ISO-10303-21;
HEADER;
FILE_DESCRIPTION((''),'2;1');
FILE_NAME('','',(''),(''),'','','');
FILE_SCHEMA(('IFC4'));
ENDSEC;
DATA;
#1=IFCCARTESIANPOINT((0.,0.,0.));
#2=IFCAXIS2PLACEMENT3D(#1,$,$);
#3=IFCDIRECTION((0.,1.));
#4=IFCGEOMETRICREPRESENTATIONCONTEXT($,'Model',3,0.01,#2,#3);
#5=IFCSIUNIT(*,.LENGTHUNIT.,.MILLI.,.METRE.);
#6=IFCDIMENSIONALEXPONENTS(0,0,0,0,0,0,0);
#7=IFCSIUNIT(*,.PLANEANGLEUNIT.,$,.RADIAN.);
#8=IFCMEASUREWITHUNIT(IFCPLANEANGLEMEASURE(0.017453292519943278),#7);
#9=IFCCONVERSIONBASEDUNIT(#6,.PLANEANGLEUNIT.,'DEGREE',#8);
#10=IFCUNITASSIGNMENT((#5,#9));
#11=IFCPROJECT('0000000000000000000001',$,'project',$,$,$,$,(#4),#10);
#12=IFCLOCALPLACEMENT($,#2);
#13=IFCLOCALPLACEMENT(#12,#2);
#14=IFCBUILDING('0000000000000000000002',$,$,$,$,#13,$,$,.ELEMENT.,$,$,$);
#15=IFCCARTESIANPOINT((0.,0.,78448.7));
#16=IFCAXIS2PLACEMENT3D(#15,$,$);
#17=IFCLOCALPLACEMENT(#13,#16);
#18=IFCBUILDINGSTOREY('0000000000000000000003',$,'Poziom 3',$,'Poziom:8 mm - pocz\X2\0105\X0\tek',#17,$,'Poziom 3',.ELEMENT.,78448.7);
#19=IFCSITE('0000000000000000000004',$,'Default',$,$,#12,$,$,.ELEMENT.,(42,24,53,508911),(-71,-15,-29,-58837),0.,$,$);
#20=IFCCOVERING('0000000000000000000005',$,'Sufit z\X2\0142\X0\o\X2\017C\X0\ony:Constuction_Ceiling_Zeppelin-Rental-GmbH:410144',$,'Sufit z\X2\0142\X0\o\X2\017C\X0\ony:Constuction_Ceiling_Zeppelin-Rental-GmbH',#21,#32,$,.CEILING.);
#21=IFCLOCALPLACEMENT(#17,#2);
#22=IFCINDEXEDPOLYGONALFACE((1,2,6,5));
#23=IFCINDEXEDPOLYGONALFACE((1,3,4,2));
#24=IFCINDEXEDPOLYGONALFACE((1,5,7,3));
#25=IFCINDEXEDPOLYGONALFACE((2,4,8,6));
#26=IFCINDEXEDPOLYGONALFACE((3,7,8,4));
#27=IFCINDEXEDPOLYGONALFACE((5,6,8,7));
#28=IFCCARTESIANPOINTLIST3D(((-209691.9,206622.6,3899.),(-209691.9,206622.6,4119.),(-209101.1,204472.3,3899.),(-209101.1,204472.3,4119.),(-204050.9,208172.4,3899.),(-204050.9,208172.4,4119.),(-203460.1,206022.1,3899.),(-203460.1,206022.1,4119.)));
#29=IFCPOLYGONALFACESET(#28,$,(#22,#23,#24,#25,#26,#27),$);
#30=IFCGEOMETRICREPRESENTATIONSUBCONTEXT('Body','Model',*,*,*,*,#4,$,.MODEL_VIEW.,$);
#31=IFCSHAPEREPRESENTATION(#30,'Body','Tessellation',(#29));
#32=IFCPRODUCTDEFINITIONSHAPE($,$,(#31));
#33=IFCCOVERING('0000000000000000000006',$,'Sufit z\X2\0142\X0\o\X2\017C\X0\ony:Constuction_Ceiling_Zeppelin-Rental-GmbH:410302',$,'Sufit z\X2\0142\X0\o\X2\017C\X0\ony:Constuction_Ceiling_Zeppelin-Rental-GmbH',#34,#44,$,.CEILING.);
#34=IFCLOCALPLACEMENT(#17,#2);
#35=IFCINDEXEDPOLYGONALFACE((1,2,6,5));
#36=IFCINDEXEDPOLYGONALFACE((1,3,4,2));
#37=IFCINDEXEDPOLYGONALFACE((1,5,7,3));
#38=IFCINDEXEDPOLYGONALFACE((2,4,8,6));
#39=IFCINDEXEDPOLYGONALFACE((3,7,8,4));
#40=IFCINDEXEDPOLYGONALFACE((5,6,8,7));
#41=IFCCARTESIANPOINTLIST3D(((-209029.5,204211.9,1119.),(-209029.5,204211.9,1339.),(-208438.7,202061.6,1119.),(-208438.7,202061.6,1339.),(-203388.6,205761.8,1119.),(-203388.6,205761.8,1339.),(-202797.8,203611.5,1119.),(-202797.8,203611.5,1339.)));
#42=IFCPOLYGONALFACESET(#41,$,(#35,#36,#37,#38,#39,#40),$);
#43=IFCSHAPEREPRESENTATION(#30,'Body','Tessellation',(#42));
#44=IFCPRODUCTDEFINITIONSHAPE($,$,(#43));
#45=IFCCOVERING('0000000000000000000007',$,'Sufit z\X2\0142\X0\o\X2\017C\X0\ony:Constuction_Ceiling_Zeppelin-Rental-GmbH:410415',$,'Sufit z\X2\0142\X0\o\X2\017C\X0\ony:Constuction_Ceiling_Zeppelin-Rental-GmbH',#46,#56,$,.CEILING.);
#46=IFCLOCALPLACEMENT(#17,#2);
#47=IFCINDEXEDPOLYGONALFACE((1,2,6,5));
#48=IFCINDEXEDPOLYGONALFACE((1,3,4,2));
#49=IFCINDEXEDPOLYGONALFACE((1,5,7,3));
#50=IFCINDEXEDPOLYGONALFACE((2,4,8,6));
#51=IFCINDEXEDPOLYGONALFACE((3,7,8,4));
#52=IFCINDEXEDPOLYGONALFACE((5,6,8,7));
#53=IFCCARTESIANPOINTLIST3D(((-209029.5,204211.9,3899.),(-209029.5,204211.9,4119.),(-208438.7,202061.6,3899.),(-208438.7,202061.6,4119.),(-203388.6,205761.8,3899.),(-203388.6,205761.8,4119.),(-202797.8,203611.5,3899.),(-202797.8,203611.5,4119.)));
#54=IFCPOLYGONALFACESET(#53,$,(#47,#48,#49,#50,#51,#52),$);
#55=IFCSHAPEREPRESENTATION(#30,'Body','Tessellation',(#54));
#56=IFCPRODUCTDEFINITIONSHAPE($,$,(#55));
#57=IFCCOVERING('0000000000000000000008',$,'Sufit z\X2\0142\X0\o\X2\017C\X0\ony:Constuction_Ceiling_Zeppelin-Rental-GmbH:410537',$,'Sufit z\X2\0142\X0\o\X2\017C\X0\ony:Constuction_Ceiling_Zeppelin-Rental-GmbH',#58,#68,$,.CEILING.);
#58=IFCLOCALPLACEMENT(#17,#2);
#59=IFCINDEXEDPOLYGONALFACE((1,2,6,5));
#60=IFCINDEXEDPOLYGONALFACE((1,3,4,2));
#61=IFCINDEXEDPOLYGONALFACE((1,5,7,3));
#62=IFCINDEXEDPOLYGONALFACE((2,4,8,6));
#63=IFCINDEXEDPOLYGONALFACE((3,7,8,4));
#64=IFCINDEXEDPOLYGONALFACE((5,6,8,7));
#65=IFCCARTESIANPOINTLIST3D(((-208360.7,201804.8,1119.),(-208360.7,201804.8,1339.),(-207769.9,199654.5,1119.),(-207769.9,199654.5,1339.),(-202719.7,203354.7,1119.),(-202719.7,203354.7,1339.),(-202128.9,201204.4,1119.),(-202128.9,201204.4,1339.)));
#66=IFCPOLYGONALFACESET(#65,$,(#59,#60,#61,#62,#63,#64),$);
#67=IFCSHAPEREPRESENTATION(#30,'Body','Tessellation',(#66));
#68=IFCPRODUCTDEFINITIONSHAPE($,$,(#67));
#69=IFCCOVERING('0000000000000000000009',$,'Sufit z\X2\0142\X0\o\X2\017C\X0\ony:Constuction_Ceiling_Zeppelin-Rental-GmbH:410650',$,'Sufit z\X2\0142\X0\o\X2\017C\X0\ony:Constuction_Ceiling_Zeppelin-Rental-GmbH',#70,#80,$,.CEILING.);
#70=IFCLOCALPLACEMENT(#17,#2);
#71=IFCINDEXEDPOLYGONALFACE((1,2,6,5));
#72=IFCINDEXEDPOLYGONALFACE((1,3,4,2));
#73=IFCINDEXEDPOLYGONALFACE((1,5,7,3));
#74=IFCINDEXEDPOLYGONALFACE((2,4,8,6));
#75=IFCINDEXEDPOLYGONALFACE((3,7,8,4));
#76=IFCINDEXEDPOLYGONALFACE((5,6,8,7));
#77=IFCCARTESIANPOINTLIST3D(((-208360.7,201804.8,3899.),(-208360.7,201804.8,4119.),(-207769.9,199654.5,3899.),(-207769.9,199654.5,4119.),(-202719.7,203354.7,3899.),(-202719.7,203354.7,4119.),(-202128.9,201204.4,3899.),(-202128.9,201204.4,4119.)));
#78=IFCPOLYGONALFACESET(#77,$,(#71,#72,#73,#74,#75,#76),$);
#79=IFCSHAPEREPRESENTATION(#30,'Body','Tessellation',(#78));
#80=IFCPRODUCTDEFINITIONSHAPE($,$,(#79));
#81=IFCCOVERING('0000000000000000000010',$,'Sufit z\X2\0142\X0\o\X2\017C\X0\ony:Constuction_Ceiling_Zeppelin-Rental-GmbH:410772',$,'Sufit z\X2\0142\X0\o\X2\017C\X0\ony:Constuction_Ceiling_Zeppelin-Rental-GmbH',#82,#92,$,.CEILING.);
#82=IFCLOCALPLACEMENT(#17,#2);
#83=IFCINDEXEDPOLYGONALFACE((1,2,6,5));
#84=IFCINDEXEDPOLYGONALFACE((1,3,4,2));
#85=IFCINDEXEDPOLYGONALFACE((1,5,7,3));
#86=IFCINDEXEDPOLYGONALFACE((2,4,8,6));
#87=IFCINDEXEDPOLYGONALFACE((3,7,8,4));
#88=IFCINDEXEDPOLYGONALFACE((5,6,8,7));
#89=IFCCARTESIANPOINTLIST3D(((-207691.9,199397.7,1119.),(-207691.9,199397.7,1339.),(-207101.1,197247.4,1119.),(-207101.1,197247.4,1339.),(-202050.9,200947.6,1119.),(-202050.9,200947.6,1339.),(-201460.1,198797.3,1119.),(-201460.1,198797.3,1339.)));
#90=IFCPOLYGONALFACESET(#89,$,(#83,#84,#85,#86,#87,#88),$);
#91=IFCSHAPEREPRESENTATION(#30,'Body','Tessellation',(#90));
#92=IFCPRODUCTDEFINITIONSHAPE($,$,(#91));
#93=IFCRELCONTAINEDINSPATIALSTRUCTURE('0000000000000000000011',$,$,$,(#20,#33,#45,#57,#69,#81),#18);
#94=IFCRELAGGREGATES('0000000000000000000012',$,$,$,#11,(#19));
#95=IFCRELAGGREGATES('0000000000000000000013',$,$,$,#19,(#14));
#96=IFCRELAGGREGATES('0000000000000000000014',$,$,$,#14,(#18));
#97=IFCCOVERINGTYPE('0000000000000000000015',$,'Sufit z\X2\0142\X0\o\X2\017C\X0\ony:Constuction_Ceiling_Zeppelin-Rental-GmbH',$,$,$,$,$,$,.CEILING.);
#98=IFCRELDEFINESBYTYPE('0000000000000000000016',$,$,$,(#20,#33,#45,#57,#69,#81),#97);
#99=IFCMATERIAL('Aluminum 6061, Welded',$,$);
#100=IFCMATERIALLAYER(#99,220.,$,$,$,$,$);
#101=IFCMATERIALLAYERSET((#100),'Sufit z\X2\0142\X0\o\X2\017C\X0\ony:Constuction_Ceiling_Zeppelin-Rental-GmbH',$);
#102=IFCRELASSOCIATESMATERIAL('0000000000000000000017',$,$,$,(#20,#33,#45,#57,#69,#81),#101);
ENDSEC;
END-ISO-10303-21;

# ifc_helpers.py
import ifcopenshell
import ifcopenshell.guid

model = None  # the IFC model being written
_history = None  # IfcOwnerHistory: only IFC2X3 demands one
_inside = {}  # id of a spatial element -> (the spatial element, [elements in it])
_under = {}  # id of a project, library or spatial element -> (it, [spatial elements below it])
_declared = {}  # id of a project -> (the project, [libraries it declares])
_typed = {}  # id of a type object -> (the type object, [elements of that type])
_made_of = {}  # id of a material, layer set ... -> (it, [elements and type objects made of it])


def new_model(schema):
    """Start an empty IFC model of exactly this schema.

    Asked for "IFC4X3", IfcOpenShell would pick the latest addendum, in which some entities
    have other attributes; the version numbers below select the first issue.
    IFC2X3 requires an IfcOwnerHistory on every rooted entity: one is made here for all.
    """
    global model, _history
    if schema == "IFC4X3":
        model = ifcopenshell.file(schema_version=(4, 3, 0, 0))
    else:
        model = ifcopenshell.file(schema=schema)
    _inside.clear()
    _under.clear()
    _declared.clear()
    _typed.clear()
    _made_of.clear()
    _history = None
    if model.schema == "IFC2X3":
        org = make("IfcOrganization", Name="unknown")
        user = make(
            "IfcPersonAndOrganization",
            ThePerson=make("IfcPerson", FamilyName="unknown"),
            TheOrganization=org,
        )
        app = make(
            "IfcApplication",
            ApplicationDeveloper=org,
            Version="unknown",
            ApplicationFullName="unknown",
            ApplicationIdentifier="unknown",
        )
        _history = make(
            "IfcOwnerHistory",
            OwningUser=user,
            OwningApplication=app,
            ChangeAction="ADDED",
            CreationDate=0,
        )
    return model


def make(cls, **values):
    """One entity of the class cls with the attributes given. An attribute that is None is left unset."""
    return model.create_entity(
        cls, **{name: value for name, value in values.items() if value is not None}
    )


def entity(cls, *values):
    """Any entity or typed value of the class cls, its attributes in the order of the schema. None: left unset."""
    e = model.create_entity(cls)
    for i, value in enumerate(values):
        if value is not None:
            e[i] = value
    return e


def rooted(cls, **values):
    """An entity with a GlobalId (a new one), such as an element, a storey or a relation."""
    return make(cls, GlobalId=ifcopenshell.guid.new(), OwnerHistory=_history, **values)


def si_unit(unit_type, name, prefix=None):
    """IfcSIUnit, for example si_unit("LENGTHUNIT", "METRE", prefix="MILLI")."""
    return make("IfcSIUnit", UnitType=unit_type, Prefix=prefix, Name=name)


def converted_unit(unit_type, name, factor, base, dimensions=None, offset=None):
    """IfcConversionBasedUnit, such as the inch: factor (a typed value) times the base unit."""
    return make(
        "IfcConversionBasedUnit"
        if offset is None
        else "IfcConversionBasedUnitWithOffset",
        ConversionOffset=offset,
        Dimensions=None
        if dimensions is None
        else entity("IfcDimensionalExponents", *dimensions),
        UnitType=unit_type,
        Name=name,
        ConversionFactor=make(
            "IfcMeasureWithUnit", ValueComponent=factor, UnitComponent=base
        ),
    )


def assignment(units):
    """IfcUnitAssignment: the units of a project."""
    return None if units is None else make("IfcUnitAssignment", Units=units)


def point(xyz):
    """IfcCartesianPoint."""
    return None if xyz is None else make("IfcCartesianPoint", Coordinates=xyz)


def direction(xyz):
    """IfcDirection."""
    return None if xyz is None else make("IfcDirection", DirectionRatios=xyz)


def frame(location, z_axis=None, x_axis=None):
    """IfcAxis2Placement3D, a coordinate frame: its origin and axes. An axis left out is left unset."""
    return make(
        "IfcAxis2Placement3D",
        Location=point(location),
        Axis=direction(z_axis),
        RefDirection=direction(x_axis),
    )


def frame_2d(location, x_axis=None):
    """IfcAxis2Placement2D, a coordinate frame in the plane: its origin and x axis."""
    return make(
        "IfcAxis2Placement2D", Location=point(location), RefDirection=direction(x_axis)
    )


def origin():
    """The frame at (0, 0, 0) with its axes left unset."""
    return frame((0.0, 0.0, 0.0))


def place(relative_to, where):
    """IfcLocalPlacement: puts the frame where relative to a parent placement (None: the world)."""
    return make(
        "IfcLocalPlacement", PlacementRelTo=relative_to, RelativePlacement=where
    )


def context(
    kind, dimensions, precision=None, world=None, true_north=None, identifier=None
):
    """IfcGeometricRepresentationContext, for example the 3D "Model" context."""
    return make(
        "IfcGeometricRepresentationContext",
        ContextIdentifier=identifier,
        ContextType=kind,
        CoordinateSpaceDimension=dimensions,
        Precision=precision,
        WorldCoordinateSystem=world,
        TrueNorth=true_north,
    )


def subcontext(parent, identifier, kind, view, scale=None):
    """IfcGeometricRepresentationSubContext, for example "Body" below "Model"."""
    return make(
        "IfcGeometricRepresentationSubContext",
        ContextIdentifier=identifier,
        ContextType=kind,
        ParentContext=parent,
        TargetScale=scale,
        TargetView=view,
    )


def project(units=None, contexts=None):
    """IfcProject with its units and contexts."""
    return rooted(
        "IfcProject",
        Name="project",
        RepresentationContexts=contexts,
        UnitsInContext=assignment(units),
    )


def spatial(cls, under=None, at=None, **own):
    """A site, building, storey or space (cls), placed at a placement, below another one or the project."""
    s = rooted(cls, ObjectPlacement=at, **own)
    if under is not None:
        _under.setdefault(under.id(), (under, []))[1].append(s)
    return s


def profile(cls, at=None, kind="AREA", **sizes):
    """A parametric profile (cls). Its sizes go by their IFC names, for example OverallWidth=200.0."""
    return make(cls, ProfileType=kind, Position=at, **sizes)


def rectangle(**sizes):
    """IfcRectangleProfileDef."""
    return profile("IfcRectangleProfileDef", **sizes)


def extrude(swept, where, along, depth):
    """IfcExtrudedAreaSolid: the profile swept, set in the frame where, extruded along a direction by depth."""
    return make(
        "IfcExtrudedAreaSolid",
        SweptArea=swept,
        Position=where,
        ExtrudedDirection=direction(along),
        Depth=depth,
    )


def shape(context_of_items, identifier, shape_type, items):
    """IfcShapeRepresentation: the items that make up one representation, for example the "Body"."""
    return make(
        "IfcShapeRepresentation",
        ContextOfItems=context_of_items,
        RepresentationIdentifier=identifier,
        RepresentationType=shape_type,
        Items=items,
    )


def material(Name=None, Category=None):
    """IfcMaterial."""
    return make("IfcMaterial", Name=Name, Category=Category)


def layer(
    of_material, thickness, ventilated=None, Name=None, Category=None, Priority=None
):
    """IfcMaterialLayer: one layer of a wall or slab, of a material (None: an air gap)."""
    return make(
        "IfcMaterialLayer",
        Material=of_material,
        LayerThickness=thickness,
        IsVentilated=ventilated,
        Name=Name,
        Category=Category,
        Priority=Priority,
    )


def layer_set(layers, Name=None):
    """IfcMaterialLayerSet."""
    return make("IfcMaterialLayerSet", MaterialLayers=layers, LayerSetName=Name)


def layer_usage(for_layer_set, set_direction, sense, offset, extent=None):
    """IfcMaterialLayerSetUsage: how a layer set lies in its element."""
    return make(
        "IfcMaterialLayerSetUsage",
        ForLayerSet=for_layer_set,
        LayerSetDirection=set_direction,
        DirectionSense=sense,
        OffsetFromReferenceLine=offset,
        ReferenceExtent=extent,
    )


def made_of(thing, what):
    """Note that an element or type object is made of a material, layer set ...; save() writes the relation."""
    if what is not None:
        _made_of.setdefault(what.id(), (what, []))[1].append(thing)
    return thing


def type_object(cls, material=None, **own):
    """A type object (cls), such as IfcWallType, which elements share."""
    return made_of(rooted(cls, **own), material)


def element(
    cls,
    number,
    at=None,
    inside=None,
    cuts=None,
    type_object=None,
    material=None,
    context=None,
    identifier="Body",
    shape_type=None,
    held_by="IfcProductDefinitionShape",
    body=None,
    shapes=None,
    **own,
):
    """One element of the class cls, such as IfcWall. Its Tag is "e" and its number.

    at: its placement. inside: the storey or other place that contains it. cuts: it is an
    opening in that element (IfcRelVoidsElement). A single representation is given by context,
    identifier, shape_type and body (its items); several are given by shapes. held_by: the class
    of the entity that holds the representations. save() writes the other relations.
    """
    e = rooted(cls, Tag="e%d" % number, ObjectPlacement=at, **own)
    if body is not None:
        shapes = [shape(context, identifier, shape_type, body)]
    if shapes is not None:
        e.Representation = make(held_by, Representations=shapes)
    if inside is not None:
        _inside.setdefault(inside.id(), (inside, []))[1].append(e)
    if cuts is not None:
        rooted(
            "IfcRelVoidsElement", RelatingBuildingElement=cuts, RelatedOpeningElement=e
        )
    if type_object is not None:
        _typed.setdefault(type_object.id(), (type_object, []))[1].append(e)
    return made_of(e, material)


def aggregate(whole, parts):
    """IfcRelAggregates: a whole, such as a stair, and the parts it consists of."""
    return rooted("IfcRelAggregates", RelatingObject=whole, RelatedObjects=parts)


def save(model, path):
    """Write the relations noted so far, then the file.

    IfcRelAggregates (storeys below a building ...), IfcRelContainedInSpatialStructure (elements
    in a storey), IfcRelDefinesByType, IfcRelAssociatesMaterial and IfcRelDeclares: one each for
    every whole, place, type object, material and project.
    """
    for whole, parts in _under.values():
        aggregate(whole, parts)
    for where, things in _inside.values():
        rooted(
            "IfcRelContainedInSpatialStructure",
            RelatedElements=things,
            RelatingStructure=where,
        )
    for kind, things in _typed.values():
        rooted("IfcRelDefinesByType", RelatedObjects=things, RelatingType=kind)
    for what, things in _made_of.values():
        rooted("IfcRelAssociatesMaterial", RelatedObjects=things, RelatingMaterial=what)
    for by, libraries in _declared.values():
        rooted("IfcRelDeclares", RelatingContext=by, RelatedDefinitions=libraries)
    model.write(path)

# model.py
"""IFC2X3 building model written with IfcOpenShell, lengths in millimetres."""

from ifc_helpers import new_model, entity, si_unit, converted_unit, direction, frame, frame_2d, origin, place, context, subcontext, project, spatial, rectangle, extrude, material, layer, layer_set, layer_usage, type_object, element, save


model = new_model("IFC2X3")

# Units and contexts
model_context = context("Model", 3, precision=0.01, world=origin(), true_north=direction((0.0, 1.0)))
body_context = subcontext(model_context, "Body", "Model", "MODEL_VIEW")
ifc_project = project(units=[si_unit("LENGTHUNIT", "METRE", prefix="MILLI"), converted_unit("PLANEANGLEUNIT", "DEGREE", entity("IfcPlaneAngleMeasure", 0.017453292519943278), si_unit("PLANEANGLEUNIT", "RADIAN"), dimensions=[0, 0, 0, 0, 0, 0, 0])], contexts=[model_context])

# Site, building, storey
site_placement = place(None, origin())
site = spatial("IfcSite", under=ifc_project, at=site_placement, Name="Default", CompositionType="ELEMENT", RefLatitude=(42, 24, 53, 508911), RefLongitude=(-71, -15, -29, -58837), RefElevation=0.0)
building_placement = place(site_placement, origin())
building = spatial("IfcBuilding", under=site, at=building_placement, CompositionType="ELEMENT")
storey_placement = place(building_placement, frame((0.0, 0.0, 78448.7)))
storey = spatial("IfcBuildingStorey", under=building, at=storey_placement, Name="Poziom 3", ObjectType="Poziom:8 mm - początek", LongName="Poziom 3", CompositionType="ELEMENT", Elevation=78448.7)

# Coverings
ifc_material_1 = material(Name="Aluminum 6061, Welded")
ifc_layer_1 = layer(ifc_material_1, 220.0)
ifc_layer_set_1 = layer_set([ifc_layer_1], Name="Sufit złożony:Constuction_Ceiling_Zeppelin-Rental-GmbH")
covering_type = type_object("IfcCoveringType", Name="Sufit złożony:Constuction_Ceiling_Zeppelin-Rental-GmbH", PredefinedType="CEILING")
ifc_layer_usage_1 = layer_usage(ifc_layer_set_1, "AXIS3", "NEGATIVE", 220.0)
covering_1_placement = place(storey_placement, origin())
element("IfcCovering", 1, at=covering_1_placement, inside=storey, type_object=covering_type, material=ifc_layer_usage_1, Name="Sufit złożony:Constuction_Ceiling_Zeppelin-Rental-GmbH:410144", ObjectType="Sufit złożony:Constuction_Ceiling_Zeppelin-Rental-GmbH", PredefinedType="CEILING", context=body_context, shape_type="SweptSolid", body=[
    extrude(rectangle(XDim=5850.0, YDim=2230.0, at=frame_2d((0.0, 0.0), x_axis=(1.0, 0.0))), frame((-206576.0, 206322.4, 3899.0), z_axis=(0.0, 0.0, 1.0), x_axis=(-0.964267, -0.264931, 0.0)), (0.0, 0.0, 1.0), 220.0),
])
ifc_layer_usage_2 = layer_usage(ifc_layer_set_1, "AXIS3", "NEGATIVE", 220.0)
covering_2_placement = place(storey_placement, origin())
element("IfcCovering", 2, at=covering_2_placement, inside=storey, type_object=covering_type, material=ifc_layer_usage_2, Name="Sufit złożony:Constuction_Ceiling_Zeppelin-Rental-GmbH:410302", ObjectType="Sufit złożony:Constuction_Ceiling_Zeppelin-Rental-GmbH", PredefinedType="CEILING", context=body_context, shape_type="SweptSolid", body=[
    extrude(rectangle(XDim=5850.0, YDim=2230.0, at=frame_2d((0.0, 0.0), x_axis=(1.0, 0.0))), frame((-205913.6, 203911.7, 1119.0), z_axis=(0.0, 0.0, 1.0), x_axis=(-0.964267, -0.264931, 0.0)), (0.0, 0.0, 1.0), 220.0),
])
ifc_layer_usage_3 = layer_usage(ifc_layer_set_1, "AXIS3", "NEGATIVE", 220.0)
covering_3_placement = place(storey_placement, origin())
element("IfcCovering", 3, at=covering_3_placement, inside=storey, type_object=covering_type, material=ifc_layer_usage_3, Name="Sufit złożony:Constuction_Ceiling_Zeppelin-Rental-GmbH:410415", ObjectType="Sufit złożony:Constuction_Ceiling_Zeppelin-Rental-GmbH", PredefinedType="CEILING", context=body_context, shape_type="SweptSolid", body=[
    extrude(rectangle(XDim=5850.0, YDim=2230.0, at=frame_2d((0.0, 0.0), x_axis=(1.0, 0.0))), frame((-205913.6, 203911.7, 3899.0), z_axis=(0.0, 0.0, 1.0), x_axis=(-0.964267, -0.264931, 0.0)), (0.0, 0.0, 1.0), 220.0),
])
ifc_layer_usage_4 = layer_usage(ifc_layer_set_1, "AXIS3", "NEGATIVE", 220.0)
covering_4_placement = place(storey_placement, origin())
element("IfcCovering", 4, at=covering_4_placement, inside=storey, type_object=covering_type, material=ifc_layer_usage_4, Name="Sufit złożony:Constuction_Ceiling_Zeppelin-Rental-GmbH:410537", ObjectType="Sufit złożony:Constuction_Ceiling_Zeppelin-Rental-GmbH", PredefinedType="CEILING", context=body_context, shape_type="SweptSolid", body=[
    extrude(rectangle(XDim=5850.0, YDim=2230.0, at=frame_2d((0.0, 0.0), x_axis=(1.0, 0.0))), frame((-205244.8, 201504.6, 1119.0), z_axis=(0.0, 0.0, 1.0), x_axis=(-0.964267, -0.264931, 0.0)), (0.0, 0.0, 1.0), 220.0),
])
ifc_layer_usage_5 = layer_usage(ifc_layer_set_1, "AXIS3", "NEGATIVE", 220.0)
covering_5_placement = place(storey_placement, origin())
element("IfcCovering", 5, at=covering_5_placement, inside=storey, type_object=covering_type, material=ifc_layer_usage_5, Name="Sufit złożony:Constuction_Ceiling_Zeppelin-Rental-GmbH:410650", ObjectType="Sufit złożony:Constuction_Ceiling_Zeppelin-Rental-GmbH", PredefinedType="CEILING", context=body_context, shape_type="SweptSolid", body=[
    extrude(rectangle(XDim=5850.0, YDim=2230.0, at=frame_2d((0.0, 0.0), x_axis=(1.0, 0.0))), frame((-205244.8, 201504.6, 3899.0), z_axis=(0.0, 0.0, 1.0), x_axis=(-0.964267, -0.264931, 0.0)), (0.0, 0.0, 1.0), 220.0),
])
ifc_layer_usage_6 = layer_usage(ifc_layer_set_1, "AXIS3", "NEGATIVE", 220.0)
covering_6_placement = place(storey_placement, origin())
element("IfcCovering", 6, at=covering_6_placement, inside=storey, type_object=covering_type, material=ifc_layer_usage_6, Name="Sufit złożony:Constuction_Ceiling_Zeppelin-Rental-GmbH:410772", ObjectType="Sufit złożony:Constuction_Ceiling_Zeppelin-Rental-GmbH", PredefinedType="CEILING", context=body_context, shape_type="SweptSolid", body=[
    extrude(rectangle(XDim=5850.0, YDim=2230.0, at=frame_2d((0.0, 0.0), x_axis=(1.0, 0.0))), frame((-204576.0, 199097.5, 1119.0), z_axis=(0.0, 0.0, 1.0), x_axis=(-0.964267, -0.264931, 0.0)), (0.0, 0.0, 1.0), 220.0),
])

save(model, "model.ifc")
